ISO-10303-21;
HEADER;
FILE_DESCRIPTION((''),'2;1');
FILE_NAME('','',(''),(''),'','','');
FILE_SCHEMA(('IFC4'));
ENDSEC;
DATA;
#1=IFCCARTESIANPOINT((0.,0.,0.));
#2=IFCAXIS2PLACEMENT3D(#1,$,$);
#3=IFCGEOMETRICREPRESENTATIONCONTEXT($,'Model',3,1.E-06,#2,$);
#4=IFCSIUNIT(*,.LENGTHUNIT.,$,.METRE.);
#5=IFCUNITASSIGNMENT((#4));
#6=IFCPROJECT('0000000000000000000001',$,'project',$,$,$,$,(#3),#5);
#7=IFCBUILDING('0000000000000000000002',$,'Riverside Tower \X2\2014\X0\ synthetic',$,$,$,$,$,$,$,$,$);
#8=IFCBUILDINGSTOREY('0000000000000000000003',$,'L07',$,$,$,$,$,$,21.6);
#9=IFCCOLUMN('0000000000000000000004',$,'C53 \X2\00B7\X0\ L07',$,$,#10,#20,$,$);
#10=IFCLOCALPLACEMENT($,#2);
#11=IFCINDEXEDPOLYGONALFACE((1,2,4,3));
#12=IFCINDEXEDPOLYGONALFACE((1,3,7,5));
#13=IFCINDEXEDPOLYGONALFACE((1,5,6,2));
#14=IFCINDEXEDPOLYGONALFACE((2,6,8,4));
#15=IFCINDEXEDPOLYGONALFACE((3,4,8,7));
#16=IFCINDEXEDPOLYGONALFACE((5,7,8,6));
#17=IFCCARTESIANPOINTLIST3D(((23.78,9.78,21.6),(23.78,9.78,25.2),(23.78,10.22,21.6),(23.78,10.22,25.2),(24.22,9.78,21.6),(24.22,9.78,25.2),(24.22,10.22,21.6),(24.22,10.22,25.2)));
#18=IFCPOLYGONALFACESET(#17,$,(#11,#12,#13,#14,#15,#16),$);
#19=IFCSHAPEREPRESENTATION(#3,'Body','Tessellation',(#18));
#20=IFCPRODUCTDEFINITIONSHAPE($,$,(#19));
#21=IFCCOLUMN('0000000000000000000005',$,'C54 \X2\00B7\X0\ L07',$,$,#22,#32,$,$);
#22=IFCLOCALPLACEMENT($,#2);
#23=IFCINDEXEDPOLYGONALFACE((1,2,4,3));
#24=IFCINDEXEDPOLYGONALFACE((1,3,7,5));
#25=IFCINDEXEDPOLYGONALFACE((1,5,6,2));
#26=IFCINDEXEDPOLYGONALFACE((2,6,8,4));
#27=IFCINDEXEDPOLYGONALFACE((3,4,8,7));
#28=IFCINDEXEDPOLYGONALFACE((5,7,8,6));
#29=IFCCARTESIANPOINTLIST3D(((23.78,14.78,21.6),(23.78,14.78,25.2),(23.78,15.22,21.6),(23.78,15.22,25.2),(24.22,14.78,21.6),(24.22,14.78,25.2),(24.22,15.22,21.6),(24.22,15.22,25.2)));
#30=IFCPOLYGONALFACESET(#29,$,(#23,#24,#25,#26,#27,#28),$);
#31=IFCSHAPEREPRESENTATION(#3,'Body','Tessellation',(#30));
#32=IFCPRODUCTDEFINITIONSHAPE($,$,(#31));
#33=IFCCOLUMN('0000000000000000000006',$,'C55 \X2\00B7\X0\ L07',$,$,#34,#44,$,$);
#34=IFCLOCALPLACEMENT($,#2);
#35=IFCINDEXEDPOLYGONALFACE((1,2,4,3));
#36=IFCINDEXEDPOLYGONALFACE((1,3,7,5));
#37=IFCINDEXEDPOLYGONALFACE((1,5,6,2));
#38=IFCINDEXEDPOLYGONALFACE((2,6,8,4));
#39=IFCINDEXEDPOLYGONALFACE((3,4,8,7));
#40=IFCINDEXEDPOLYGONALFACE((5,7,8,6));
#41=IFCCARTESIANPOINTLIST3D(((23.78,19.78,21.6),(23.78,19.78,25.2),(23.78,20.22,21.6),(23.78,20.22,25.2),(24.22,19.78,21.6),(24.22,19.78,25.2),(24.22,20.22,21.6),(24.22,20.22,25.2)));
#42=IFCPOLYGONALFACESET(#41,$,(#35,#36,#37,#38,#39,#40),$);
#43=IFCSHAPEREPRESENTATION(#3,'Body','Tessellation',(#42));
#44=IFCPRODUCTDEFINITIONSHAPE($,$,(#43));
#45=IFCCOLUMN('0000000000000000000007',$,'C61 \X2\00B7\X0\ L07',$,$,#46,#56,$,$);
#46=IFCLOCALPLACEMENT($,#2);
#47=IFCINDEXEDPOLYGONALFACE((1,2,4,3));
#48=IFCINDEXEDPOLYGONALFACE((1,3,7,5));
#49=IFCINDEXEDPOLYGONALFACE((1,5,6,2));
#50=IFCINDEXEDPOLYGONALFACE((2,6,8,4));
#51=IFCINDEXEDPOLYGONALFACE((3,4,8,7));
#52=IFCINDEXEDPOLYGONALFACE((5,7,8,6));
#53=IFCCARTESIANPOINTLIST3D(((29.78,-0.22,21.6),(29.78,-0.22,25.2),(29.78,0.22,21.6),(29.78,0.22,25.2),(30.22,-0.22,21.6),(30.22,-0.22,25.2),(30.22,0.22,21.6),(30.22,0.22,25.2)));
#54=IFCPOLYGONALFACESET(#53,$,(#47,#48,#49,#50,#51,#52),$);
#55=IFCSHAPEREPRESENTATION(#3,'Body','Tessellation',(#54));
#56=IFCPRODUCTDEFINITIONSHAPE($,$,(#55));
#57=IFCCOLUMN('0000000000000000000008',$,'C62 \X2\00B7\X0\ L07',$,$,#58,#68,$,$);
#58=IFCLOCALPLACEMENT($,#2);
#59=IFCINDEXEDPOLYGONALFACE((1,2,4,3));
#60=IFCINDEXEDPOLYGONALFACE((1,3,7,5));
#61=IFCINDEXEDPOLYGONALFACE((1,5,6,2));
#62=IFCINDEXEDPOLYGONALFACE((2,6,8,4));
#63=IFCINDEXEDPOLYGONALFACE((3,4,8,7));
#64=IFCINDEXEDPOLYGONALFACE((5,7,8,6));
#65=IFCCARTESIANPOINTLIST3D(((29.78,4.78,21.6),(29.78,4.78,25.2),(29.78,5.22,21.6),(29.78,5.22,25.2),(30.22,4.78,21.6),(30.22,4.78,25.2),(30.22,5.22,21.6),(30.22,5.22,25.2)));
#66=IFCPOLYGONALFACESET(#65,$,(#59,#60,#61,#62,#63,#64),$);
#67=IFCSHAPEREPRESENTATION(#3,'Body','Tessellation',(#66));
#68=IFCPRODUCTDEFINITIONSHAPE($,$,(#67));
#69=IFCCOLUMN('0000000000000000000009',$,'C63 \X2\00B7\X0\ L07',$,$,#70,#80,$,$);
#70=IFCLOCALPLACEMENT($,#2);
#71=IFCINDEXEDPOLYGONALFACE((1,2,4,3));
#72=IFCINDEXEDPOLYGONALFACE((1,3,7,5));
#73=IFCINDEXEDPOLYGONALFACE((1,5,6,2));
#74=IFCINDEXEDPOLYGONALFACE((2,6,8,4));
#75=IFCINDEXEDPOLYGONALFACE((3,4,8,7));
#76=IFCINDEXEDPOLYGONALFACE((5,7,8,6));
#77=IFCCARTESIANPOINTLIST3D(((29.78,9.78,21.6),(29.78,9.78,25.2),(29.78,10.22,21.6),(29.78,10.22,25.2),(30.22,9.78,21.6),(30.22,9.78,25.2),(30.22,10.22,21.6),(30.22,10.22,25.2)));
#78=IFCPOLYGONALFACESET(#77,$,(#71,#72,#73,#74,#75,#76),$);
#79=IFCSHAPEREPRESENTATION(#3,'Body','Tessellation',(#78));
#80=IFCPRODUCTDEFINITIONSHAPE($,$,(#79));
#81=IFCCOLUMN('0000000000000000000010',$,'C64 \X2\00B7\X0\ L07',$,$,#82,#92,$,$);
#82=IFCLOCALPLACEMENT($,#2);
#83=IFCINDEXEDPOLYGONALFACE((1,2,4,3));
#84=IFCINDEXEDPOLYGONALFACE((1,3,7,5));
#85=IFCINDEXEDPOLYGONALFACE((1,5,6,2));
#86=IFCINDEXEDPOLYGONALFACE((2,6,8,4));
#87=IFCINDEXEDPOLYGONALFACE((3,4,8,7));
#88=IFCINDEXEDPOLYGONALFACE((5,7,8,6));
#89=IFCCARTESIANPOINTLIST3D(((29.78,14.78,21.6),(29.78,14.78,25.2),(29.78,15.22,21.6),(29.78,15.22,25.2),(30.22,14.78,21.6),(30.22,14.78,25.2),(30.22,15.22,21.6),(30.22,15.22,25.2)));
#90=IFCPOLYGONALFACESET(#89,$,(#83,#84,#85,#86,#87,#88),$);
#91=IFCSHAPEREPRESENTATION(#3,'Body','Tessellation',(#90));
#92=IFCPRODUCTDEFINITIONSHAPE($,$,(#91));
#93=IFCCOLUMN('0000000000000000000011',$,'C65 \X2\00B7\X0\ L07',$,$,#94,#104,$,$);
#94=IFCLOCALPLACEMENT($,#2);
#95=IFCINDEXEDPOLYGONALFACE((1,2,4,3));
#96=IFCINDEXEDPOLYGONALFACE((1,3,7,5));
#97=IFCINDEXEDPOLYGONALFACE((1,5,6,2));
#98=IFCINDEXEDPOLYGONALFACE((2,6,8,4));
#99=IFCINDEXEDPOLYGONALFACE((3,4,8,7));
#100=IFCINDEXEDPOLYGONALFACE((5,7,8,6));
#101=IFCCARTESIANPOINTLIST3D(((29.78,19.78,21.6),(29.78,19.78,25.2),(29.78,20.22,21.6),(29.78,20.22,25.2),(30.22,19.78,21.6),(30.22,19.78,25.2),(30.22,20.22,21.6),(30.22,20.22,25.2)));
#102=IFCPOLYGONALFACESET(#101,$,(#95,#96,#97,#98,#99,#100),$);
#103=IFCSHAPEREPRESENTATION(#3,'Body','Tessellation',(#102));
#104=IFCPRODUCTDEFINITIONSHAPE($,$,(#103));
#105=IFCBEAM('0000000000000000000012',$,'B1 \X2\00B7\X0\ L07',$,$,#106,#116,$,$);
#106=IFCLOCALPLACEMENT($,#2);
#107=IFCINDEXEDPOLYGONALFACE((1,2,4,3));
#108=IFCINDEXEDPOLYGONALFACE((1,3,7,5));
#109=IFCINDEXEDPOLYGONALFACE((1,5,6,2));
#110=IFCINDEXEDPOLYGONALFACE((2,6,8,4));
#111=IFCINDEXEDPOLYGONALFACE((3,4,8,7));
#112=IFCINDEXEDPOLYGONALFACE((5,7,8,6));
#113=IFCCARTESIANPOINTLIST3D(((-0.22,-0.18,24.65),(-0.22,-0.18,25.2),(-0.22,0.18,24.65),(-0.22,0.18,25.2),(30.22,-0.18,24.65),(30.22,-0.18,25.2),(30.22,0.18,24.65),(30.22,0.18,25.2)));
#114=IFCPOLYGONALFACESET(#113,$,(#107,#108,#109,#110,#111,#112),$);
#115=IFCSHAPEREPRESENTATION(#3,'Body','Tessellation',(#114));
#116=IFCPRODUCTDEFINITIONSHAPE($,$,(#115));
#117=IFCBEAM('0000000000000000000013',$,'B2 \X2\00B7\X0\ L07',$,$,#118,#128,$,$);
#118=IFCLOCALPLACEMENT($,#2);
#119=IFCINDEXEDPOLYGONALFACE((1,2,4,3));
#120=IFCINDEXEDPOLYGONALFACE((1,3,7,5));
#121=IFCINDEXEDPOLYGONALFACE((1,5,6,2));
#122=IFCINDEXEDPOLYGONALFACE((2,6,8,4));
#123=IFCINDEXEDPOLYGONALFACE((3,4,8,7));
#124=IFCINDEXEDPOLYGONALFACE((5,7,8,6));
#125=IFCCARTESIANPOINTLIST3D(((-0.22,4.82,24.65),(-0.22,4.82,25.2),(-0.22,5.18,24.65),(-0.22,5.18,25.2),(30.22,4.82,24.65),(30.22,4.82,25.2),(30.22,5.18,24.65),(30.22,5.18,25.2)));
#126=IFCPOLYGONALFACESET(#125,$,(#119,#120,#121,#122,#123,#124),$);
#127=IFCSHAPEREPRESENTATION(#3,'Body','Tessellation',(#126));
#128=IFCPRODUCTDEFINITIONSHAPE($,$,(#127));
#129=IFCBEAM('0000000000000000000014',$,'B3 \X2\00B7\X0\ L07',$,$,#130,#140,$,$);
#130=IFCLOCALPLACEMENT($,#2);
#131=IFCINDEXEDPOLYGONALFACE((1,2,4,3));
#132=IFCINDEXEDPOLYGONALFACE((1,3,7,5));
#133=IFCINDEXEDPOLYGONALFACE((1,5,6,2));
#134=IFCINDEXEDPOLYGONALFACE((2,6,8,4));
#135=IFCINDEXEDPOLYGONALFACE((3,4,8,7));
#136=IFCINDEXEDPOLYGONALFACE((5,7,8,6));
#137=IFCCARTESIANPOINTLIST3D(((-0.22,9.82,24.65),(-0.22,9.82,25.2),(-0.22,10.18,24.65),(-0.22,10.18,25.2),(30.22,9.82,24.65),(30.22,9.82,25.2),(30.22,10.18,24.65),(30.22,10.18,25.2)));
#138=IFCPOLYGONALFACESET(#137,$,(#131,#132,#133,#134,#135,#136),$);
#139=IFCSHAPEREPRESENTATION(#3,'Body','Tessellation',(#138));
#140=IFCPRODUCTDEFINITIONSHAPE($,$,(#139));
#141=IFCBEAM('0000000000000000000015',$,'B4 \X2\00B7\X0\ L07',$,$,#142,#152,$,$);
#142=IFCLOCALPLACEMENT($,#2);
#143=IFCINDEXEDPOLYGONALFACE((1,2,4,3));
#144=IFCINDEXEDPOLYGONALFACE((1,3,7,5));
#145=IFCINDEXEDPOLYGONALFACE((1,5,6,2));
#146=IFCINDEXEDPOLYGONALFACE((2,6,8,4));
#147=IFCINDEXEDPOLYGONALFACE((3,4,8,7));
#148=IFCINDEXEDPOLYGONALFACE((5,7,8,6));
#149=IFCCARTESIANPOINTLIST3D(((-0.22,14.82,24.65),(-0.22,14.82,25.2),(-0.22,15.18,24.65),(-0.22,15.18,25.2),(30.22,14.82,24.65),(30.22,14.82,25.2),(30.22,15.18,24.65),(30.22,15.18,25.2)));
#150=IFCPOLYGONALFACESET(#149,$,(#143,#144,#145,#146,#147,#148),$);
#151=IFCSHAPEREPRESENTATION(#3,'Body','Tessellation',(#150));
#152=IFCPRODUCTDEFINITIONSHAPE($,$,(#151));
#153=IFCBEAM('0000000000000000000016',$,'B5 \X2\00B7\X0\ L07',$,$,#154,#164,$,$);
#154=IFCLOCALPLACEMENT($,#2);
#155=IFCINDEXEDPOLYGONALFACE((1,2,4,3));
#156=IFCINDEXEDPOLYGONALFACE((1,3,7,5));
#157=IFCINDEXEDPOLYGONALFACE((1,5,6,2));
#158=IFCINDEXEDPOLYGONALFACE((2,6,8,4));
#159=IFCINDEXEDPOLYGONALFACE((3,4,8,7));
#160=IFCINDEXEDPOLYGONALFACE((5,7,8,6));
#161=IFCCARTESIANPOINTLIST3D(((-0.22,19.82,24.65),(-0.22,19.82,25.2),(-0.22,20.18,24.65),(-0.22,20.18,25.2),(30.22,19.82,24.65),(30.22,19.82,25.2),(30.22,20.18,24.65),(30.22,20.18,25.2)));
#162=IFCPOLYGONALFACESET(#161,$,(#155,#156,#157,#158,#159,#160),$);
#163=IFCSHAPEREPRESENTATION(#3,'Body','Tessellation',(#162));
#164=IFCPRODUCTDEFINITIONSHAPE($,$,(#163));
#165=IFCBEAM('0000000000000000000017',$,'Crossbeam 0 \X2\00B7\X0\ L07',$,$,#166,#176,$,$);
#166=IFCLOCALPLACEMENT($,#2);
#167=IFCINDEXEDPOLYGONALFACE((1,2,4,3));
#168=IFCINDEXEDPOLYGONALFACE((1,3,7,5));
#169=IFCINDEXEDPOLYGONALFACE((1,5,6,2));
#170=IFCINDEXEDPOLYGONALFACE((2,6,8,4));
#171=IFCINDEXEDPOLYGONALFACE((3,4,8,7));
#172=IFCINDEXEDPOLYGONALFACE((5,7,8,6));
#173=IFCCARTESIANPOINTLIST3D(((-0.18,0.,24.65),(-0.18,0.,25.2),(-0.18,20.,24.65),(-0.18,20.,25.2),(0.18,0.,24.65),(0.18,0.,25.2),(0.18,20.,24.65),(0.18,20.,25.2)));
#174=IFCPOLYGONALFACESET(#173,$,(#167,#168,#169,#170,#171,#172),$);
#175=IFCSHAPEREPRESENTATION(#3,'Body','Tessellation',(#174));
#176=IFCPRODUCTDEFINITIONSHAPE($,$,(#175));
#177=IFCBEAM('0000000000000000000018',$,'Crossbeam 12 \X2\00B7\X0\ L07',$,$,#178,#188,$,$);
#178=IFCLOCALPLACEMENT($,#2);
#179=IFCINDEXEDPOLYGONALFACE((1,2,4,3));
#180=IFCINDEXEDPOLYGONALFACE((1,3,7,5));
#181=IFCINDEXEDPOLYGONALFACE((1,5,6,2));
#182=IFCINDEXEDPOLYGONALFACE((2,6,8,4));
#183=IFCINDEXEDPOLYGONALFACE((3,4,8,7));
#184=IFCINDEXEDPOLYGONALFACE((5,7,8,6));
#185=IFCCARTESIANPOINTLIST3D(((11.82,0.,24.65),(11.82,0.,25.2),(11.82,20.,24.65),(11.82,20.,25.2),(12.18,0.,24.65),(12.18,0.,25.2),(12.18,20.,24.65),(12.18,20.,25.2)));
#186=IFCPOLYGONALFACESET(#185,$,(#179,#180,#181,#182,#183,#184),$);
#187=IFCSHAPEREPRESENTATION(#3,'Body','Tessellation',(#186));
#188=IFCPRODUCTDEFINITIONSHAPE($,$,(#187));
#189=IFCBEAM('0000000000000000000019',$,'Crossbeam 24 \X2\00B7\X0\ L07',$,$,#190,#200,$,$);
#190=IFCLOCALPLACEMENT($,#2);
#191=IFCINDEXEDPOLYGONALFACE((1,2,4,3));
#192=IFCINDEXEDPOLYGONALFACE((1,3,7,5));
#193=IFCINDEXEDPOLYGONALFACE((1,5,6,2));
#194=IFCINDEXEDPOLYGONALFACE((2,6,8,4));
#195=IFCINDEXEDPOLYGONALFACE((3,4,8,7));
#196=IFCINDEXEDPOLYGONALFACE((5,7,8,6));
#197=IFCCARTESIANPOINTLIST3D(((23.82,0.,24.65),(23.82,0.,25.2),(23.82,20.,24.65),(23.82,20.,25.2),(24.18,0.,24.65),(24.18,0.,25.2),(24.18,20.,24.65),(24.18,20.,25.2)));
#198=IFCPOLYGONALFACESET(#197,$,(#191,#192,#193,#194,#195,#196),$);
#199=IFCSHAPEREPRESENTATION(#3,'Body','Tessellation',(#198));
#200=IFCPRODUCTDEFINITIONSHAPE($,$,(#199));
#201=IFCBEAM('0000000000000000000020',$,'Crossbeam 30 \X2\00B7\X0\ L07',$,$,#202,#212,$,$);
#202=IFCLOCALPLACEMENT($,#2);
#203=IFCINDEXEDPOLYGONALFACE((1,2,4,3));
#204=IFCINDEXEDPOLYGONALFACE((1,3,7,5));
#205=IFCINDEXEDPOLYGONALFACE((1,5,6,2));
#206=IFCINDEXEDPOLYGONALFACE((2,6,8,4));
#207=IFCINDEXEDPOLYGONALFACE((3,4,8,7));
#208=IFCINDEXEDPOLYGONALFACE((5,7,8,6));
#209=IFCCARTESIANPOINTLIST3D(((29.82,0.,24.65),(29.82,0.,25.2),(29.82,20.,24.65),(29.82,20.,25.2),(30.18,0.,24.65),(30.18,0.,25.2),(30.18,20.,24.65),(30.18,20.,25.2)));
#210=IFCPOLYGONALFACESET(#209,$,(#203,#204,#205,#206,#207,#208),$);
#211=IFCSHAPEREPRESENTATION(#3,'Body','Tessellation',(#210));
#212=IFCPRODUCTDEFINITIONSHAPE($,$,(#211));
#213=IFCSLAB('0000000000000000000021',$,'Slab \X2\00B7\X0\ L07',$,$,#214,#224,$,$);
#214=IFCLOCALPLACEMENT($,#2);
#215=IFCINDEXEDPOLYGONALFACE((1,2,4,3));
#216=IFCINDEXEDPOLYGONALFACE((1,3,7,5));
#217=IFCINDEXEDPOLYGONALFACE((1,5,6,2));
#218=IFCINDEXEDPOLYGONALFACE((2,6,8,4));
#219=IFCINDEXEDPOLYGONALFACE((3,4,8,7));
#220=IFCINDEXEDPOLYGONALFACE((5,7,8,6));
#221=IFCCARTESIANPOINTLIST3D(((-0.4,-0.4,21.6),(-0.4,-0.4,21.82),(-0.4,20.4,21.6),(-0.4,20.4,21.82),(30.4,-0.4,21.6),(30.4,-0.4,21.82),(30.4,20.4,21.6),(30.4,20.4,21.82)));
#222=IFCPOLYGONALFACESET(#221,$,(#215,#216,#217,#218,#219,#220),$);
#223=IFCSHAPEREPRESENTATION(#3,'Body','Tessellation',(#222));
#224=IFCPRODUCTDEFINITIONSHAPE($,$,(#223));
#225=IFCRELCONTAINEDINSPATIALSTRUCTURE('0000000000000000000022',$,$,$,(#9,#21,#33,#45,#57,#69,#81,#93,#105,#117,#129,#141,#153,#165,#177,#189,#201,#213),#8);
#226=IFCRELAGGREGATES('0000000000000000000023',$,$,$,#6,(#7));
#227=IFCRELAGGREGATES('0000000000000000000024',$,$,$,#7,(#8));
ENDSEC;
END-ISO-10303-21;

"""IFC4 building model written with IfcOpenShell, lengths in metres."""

from ifc_helpers import new_model, si_unit, frame, origin, place, context, project, spatial, rectangle, extrude, element, save


model = new_model("IFC4")

# Units and contexts
model_context = context("Model", 3, precision=1e-06, world=origin())
ifc_project = project(units=[si_unit("LENGTHUNIT", "METRE")], contexts=[model_context])

# Building, storey
building = spatial("IfcBuilding", under=ifc_project, Name="Riverside Tower — synthetic")
storey = spatial("IfcBuildingStorey", under=building, Name="L07", Elevation=21.6)

# Columns
for number, where, name in (
    (1, (24.0, 10.0, 21.6), "C53 · L07"),
    (2, (24.0, 15.0, 21.6), "C54 · L07"),
    (3, (24.0, 20.0, 21.6), "C55 · L07"),
    (4, (30.0, 0.0, 21.6), "C61 · L07"),
    (5, (30.0, 5.0, 21.6), "C62 · L07"),
    (6, (30.0, 10.0, 21.6), "C63 · L07"),
    (7, (30.0, 15.0, 21.6), "C64 · L07"),
    (8, (30.0, 20.0, 21.6), "C65 · L07"),
):
    element("IfcColumn", number, at=place(None, frame(where)), inside=storey, Name=name, context=model_context, shape_type="SweptSolid", body=[
        extrude(rectangle(XDim=0.44, YDim=0.44), origin(), (0.0, 0.0, 1.0), 3.6),
    ])

# Beams
for number, where, name in (
    (9, (15.0, 0.0, 24.65), "B1 · L07"),
    (10, (15.0, 5.0, 24.65), "B2 · L07"),
    (11, (15.0, 10.0, 24.65), "B3 · L07"),
    (12, (15.0, 15.0, 24.65), "B4 · L07"),
    (13, (15.0, 20.0, 24.65), "B5 · L07"),
):
    element("IfcBeam", number, at=place(None, frame(where)), inside=storey, Name=name, context=model_context, shape_type="SweptSolid", body=[
        extrude(rectangle(XDim=30.44, YDim=0.36), origin(), (0.0, 0.0, 1.0), 0.55),
    ])
for number, where, name in (
    (14, (0.0, 10.0, 24.65), "Crossbeam 0 · L07"),
    (15, (12.0, 10.0, 24.65), "Crossbeam 12 · L07"),
    (16, (24.0, 10.0, 24.65), "Crossbeam 24 · L07"),
    (17, (30.0, 10.0, 24.65), "Crossbeam 30 · L07"),
):
    element("IfcBeam", number, at=place(None, frame(where)), inside=storey, Name=name, context=model_context, shape_type="SweptSolid", body=[
        extrude(rectangle(XDim=0.36, YDim=20.0), origin(), (0.0, 0.0, 1.0), 0.55),
    ])

# Slab
slab_placement = place(None, frame((15.0, 10.0, 21.6)))
element("IfcSlab", 18, at=slab_placement, inside=storey, Name="Slab · L07", context=model_context, shape_type="SweptSolid", body=[
    extrude(rectangle(XDim=30.8, YDim=20.8), origin(), (0.0, 0.0, 1.0), 0.22),
])

save(model, "model.ifc")
